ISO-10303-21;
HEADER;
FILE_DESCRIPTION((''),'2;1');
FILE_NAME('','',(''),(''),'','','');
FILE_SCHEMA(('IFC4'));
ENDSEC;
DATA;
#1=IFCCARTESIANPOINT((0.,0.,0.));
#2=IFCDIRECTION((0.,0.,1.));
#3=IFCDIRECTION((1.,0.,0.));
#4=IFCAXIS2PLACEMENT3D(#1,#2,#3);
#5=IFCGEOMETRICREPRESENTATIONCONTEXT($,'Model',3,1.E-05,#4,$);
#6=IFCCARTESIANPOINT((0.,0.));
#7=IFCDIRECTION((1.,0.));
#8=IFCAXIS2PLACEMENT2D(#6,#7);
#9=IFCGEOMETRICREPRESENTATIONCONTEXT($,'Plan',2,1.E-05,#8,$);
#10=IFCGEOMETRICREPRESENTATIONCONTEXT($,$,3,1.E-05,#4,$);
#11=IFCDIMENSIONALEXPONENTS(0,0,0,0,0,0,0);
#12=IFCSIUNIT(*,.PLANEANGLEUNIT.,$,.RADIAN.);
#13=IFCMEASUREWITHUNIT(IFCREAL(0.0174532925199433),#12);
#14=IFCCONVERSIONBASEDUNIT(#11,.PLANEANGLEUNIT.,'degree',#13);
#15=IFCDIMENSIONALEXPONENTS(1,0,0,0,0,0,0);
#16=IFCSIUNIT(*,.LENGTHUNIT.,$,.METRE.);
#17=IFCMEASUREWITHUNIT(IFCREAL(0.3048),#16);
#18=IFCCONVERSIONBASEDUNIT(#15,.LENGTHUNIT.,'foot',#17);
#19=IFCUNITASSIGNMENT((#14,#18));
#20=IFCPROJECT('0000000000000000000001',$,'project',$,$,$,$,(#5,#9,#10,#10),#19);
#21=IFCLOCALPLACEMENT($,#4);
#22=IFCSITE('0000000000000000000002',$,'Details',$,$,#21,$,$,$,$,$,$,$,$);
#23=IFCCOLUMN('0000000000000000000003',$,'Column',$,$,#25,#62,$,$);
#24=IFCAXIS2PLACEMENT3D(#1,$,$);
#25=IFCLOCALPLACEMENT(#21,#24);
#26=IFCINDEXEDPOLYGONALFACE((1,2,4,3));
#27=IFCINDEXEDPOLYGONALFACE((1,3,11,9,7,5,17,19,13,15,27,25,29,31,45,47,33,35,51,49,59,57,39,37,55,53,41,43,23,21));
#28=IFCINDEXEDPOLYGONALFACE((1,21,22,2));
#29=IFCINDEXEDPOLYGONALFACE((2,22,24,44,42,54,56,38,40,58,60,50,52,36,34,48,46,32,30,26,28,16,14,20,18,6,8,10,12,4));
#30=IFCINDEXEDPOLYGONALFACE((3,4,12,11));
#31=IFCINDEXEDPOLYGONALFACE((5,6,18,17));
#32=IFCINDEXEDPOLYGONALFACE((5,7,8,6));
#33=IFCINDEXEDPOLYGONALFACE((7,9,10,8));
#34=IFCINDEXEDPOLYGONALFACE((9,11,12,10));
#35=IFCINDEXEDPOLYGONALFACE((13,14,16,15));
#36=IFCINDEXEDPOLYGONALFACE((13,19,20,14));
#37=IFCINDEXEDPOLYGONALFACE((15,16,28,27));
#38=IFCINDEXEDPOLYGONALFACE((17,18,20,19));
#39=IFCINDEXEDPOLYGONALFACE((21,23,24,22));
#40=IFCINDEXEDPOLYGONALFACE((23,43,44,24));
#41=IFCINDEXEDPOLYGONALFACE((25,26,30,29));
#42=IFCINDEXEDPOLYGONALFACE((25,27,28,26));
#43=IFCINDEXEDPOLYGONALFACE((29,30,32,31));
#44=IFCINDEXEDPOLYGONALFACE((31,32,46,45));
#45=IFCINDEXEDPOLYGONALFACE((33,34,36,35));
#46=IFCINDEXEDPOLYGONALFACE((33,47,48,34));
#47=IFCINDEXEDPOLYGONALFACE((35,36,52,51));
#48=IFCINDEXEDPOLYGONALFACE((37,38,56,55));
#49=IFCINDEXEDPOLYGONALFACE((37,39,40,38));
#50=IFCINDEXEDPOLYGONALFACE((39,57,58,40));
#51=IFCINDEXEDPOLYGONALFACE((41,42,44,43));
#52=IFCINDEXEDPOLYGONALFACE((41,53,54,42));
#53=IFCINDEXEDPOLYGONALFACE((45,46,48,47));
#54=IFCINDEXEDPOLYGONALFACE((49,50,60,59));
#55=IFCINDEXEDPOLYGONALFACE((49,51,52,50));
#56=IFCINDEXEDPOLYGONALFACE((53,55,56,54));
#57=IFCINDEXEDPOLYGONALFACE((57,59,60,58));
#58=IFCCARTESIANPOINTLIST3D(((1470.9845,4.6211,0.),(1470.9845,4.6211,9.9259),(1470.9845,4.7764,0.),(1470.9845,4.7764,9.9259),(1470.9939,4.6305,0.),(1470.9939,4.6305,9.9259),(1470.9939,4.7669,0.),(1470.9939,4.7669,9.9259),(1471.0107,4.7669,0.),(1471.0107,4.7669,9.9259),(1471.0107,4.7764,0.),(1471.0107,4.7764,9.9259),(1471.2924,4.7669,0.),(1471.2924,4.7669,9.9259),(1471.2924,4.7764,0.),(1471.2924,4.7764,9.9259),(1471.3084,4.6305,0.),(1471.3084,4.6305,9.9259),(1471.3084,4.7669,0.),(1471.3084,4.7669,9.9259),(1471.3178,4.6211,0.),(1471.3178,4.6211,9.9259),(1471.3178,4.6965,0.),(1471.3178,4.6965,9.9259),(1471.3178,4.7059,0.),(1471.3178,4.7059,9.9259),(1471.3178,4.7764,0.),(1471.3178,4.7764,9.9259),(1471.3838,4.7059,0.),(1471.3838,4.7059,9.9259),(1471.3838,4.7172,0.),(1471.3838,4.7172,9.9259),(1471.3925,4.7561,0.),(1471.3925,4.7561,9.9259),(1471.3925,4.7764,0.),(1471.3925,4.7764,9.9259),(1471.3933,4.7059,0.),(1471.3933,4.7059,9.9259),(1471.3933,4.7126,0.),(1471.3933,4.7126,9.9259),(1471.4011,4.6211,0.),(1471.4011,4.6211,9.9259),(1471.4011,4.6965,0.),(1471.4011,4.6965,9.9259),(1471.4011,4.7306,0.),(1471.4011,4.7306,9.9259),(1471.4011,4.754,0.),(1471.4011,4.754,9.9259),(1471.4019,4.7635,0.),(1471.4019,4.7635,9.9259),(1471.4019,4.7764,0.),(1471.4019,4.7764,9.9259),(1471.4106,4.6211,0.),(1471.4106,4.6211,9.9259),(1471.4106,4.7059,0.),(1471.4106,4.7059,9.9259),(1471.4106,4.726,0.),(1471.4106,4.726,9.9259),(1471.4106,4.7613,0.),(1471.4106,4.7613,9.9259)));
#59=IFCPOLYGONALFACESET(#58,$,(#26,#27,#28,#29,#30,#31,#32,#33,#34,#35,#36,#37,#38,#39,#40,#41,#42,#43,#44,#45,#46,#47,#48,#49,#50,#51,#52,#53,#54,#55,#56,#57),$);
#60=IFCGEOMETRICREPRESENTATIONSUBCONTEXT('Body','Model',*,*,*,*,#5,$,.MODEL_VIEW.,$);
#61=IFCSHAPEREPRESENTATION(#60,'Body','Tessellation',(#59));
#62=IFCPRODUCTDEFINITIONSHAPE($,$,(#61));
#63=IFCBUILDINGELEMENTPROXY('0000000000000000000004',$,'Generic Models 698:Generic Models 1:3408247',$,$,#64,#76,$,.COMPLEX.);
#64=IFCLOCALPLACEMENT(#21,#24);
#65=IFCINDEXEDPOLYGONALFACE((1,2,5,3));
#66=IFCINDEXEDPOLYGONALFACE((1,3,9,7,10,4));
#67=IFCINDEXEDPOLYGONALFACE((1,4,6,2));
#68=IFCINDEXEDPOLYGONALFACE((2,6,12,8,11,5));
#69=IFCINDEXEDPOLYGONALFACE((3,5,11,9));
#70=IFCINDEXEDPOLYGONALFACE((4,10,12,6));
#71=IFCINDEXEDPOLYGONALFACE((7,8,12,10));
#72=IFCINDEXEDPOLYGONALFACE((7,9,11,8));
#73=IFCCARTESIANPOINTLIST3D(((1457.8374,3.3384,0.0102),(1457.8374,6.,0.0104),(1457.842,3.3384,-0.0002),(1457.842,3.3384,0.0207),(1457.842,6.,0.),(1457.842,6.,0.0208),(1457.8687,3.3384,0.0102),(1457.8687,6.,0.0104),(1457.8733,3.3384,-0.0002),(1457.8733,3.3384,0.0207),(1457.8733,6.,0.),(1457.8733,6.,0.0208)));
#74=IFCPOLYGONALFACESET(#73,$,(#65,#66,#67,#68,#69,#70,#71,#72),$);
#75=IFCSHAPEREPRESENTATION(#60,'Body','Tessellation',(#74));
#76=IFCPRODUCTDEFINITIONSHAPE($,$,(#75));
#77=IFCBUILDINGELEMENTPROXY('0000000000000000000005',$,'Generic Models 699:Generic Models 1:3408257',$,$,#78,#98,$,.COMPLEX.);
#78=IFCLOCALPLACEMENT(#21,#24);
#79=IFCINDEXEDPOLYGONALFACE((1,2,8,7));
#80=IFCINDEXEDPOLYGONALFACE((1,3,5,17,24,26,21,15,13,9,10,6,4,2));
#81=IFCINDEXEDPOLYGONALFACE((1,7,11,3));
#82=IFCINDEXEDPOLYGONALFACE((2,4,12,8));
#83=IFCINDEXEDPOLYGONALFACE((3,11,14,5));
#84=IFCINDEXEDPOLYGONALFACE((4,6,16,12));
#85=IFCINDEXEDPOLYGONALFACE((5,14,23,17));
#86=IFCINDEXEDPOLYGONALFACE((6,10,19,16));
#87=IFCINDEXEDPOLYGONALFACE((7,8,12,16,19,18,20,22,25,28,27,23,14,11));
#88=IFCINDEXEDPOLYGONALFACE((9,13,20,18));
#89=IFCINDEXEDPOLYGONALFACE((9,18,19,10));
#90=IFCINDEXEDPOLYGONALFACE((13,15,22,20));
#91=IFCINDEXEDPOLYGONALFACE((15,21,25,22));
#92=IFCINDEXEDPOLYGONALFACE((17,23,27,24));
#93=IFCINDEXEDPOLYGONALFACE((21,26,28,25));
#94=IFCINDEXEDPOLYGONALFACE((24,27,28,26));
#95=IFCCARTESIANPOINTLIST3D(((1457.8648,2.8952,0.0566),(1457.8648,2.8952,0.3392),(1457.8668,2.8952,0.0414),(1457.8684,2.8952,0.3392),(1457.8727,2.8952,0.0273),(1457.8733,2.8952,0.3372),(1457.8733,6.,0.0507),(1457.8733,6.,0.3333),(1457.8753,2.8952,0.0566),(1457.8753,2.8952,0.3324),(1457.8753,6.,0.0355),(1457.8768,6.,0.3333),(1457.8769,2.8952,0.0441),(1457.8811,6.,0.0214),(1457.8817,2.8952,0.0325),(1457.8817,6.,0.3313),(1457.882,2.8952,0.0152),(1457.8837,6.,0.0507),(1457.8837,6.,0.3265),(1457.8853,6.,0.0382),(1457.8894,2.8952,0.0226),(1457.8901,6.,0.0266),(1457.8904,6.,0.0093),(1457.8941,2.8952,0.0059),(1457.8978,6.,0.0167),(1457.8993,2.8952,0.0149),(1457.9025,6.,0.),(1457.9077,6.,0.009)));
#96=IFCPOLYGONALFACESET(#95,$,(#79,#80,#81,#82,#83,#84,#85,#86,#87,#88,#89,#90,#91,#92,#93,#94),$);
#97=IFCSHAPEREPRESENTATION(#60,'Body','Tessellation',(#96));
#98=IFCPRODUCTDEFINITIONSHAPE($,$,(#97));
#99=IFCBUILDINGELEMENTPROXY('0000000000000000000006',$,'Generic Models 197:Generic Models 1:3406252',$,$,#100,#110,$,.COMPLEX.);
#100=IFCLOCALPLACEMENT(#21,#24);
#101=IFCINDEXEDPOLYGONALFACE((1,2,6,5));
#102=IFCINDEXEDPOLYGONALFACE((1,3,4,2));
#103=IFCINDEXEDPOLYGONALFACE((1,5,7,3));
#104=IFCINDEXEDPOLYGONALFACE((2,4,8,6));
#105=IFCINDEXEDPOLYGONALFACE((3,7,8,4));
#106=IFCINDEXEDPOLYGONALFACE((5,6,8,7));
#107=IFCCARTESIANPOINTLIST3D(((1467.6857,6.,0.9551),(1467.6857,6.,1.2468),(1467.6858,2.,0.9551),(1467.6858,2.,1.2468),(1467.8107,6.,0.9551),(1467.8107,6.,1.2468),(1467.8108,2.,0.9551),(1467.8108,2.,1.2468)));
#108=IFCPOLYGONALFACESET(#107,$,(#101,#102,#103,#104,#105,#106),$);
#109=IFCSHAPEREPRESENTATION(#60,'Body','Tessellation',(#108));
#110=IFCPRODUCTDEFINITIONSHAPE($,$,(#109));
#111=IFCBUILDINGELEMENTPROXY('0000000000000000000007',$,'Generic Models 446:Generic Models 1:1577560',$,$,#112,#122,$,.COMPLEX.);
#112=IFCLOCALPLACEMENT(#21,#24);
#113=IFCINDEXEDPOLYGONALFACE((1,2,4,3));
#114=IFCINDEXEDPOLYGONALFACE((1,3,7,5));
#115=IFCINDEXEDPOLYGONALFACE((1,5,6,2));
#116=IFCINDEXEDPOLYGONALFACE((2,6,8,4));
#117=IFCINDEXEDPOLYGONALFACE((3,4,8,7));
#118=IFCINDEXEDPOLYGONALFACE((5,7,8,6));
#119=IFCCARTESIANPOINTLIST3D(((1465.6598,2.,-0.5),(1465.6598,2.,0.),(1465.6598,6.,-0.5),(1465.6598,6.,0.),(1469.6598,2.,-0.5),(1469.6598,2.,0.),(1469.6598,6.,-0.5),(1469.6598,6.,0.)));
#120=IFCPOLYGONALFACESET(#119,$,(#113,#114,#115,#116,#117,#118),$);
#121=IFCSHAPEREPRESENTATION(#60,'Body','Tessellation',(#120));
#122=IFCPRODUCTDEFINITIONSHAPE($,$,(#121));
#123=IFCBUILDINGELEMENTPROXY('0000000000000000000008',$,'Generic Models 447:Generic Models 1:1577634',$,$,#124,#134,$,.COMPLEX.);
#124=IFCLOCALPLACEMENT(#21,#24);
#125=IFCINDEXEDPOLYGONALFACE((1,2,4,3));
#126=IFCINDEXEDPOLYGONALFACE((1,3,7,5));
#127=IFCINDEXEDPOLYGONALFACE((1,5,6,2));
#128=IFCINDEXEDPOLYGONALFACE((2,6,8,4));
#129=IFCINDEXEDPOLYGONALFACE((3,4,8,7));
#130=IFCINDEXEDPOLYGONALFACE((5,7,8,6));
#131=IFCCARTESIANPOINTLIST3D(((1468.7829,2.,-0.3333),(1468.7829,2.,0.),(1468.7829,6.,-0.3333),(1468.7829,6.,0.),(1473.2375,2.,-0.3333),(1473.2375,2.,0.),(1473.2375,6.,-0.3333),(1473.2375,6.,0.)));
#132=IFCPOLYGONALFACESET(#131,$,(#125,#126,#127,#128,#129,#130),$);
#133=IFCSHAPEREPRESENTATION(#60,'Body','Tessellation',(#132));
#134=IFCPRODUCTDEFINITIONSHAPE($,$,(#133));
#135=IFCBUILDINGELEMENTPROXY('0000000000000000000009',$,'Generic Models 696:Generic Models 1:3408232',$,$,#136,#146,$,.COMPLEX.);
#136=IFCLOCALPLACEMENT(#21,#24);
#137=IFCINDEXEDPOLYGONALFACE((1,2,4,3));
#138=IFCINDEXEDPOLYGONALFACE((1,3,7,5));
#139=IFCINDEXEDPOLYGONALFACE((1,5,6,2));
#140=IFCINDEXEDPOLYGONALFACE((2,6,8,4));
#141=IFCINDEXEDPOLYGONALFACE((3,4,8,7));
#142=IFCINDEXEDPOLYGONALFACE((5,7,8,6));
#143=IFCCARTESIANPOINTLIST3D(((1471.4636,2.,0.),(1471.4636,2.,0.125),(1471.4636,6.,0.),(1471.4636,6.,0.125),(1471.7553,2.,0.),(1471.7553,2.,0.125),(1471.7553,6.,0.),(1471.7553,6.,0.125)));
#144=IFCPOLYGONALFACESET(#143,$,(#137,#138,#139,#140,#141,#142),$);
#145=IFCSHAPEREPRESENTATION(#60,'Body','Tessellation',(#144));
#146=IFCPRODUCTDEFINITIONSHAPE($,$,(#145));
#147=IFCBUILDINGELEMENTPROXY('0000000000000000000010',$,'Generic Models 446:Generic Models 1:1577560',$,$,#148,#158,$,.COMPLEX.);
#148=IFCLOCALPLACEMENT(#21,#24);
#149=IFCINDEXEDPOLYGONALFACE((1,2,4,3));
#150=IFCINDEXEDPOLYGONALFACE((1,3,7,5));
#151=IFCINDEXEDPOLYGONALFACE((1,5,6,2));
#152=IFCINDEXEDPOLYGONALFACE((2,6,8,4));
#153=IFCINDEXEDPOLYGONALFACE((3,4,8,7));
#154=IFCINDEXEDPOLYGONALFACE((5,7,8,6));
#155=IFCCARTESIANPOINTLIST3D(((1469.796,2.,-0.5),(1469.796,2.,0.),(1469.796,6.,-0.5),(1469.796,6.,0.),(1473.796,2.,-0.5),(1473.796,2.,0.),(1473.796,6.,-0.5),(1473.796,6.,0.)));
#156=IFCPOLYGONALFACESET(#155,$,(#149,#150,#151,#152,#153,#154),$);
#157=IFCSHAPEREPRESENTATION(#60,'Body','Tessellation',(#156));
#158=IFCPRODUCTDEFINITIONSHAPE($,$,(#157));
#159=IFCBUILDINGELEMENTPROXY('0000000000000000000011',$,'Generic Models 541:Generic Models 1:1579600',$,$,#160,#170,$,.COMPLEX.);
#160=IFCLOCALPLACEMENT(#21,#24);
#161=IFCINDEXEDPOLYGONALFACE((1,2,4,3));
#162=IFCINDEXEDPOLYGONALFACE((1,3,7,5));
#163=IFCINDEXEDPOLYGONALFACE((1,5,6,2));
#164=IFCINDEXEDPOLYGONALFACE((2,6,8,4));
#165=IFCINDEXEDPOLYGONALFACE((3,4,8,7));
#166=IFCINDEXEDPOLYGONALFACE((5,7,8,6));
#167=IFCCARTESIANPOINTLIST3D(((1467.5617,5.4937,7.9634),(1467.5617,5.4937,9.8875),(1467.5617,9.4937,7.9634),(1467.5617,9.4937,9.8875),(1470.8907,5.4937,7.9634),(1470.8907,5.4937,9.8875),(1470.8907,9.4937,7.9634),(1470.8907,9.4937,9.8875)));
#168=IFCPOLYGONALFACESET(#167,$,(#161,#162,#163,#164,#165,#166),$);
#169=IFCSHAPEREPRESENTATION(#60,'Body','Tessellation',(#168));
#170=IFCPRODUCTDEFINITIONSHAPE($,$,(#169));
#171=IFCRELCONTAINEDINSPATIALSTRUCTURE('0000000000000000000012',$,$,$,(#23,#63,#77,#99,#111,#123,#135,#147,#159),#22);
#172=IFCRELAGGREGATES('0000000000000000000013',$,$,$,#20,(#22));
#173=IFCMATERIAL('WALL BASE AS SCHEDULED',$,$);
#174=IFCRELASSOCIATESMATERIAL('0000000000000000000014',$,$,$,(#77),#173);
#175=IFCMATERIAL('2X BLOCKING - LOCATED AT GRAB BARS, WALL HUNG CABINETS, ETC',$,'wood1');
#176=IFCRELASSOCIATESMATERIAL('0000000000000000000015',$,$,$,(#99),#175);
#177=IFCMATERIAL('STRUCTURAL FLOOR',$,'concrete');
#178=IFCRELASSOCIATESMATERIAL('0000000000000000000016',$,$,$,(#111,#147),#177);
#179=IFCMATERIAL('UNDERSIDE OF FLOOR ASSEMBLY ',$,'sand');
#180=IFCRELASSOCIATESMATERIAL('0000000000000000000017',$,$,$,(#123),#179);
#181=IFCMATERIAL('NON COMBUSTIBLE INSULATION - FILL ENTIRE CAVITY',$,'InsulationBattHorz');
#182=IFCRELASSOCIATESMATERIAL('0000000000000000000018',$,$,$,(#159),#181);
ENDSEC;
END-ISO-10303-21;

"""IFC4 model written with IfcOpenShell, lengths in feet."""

from ifc_helpers import new_model, entity, si_unit, converted_unit, frame, origin_with_axes, origin_2d_with_axis, place, context, subcontext, project, spatial, polyline, line, indexed_curve, outline, extrude, material, element, save


model = new_model("IFC4")

# Units and contexts
model_context = context("Model", 3, precision=1e-05, world=origin_with_axes())
plan_context = context("Plan", 2, precision=1e-05, world=origin_2d_with_axis())
context_of_model = context(None, 3, precision=1e-05, world=origin_with_axes())
body_context = subcontext(model_context, "Body", "Model", "MODEL_VIEW")
ifc_project = project(units=[converted_unit("PLANEANGLEUNIT", "degree", entity("IfcReal", 0.0174532925199433), si_unit("PLANEANGLEUNIT", "RADIAN"), dimensions=[0, 0, 0, 0, 0, 0, 0]), converted_unit("LENGTHUNIT", "foot", entity("IfcReal", 0.3048), si_unit("LENGTHUNIT", "METRE"), dimensions=[1, 0, 0, 0, 0, 0, 0])], contexts=[model_context, plan_context, context_of_model, context_of_model])

# Site
site_placement = place(None, origin_with_axes())
site = spatial("IfcSite", under=ifc_project, at=site_placement, Name="Details")

# Column
for number, where, z_axis, x_axis, name in (
    (1, (1470.9845, 4.6211, 0.0), (0.0, 0.0, 1.0), (1.0, 0.0, 0.0), "Column"),
):
    element("IfcColumn", number, at=place(site_placement, frame(where, z_axis=z_axis, x_axis=x_axis)), inside=site, Name=name, context=body_context, shape_type="SweptSolid", body=[
        extrude(outline(polyline([(-0.041, -0.1159), (-0.0057, -0.1159), (0.0077, -0.0986), (0.0144, -0.0986), (0.0144, -0.1159), (0.0992, -0.1159), (0.0992, -0.1064), (0.0238, -0.1064), (0.0238, -0.0231), (0.0992, -0.0231), (0.0992, 0.3102), (-0.0561, 0.3102), (-0.0561, 0.284), (-0.0466, 0.284), (-0.0466, 0.3008), (0.0898, 0.3008), (0.0898, -0.0137), (-0.0466, -0.0137), (-0.0466, 0.0023), (-0.0561, 0.0023), (-0.0561, -0.0231), (0.0144, -0.0231), (0.0144, -0.0891), (0.0031, -0.0891), (-0.0103, -0.1064), (-0.0337, -0.1064), (-0.0358, -0.0978), (-0.0561, -0.0978), (-0.0561, -0.1072), (-0.0432, -0.1072), (-0.041, -0.1159)])), frame((0.3102, 0.0992, 0.0), z_axis=(0.0, 0.0, -1.0), x_axis=(0.0, -1.0, 0.0)), (0.0, 0.0, -1.0), 9.9259),
    ])

# Building element proxies
proxy_1_placement = place(site_placement, frame((1457.8375, 6.0, 0.0), z_axis=(0.0, -1.0, 0.0), x_axis=(0.0, 0.0, 1.0)))
element("IfcBuildingElementProxy", 2, at=proxy_1_placement, inside=site, Name="Generic Models 698:Generic Models 1:3408247", PredefinedType="COMPLEX", context=body_context, shape_type="SweptSolid", body=[
    extrude(outline(polyline([(0.0201, 0.0), (0.0107, 0.0065), (0.0093, 0.0178), (-0.0175, 0.0016), (-0.016, -0.0097), (-0.0066, -0.0162), (0.0201, 0.0)])), frame((0.0104, -0.0186, 0.0), z_axis=(0.0, 0.0, -1.0), x_axis=(0.51911, -0.854707, 0.0)), (-0.000034, 0.000057, -1.0), 2.6616),
])
ifc_material_1 = material(Name="WALL BASE AS SCHEDULED")
proxy_2_placement = place(site_placement, frame((1457.8733, 6.0, 0.0), z_axis=(0.0, -1.0, 0.0), x_axis=(0.0, 0.0, 1.0)))
element("IfcBuildingElementProxy", 3, at=proxy_2_placement, inside=site, material=ifc_material_1, Name="Generic Models 699:Generic Models 1:3408257", PredefinedType="COMPLEX", context=body_context, shape_type="SweptSolid", body=[
    extrude(outline(polyline([(0.2206, 0.0), (0.2204, 0.0036), (0.2182, 0.0083), (0.2132, 0.01), (-0.0621, -0.0058), (-0.0747, -0.0049), (-0.0865, -0.0007), (-0.0969, 0.0063), (-0.1051, 0.0158), (-0.1138, 0.0101), (-0.1038, -0.0014), (-0.0912, -0.01), (-0.0768, -0.0151), (-0.0615, -0.0162), (0.2206, 0.0)])), frame((0.113, -0.0126, 0.0), z_axis=(0.0, 0.0, -1.0), x_axis=(0.998358, 0.057286, 0.0)), (0.002054, -0.002598, -0.999995), 3.1048),
])
ifc_material_2 = material(Name="2X BLOCKING - LOCATED AT GRAB BARS, WALL HUNG CABINETS, ETC", Category="wood1")
for number, where, z_axis, x_axis, name in (
    (4, (1467.6857, 6.0, 0.9551), (0.0, -1.0, 0.0), (0.0, 0.0, 1.0), "Generic Models 197:Generic Models 1:3406252"),
):
    element("IfcBuildingElementProxy", number, at=place(site_placement, frame(where, z_axis=z_axis, x_axis=x_axis)), inside=site, material=ifc_material_2, Name=name, PredefinedType="COMPLEX", context=body_context, shape_type="SweptSolid", body=[
        extrude(outline(polyline([(-0.0625, -0.1458), (0.0625, -0.1458), (0.0625, 0.1458), (-0.0625, 0.1458), (-0.0625, -0.1458)])), frame((0.1458, -0.0625, 0.0), z_axis=(0.0, 0.0, -1.0), x_axis=(0.0, 1.0, 0.0)), (0.0, 0.0, -1.0), 4.0),
    ])
ifc_material_3 = material(Name="STRUCTURAL FLOOR", Category="concrete")
proxy_3_placement = place(site_placement, frame((1465.6598, 6.0, -0.5), z_axis=(0.0, -1.0, 0.0), x_axis=(0.0, 0.0, 1.0)))
element("IfcBuildingElementProxy", 5, at=proxy_3_placement, inside=site, material=ifc_material_3, Name="Generic Models 446:Generic Models 1:1577560", PredefinedType="COMPLEX", context=body_context, shape_type="SweptSolid", body=[
    extrude(outline(polyline([(-2.0, -0.25), (2.0, -0.25), (2.0, 0.25), (-2.0, 0.25), (-2.0, -0.25)])), frame((0.25, -2.0, 0.0), z_axis=(0.0, 0.0, -1.0), x_axis=(0.0, 1.0, 0.0)), (0.0, 0.0, -1.0), 4.0),
])
ifc_material_4 = material(Name="UNDERSIDE OF FLOOR ASSEMBLY ", Category="sand")
proxy_4_placement = place(site_placement, frame((1468.7829, 6.0, -0.3333), z_axis=(0.0, -1.0, 0.0), x_axis=(0.0, 0.0, 1.0)))
element("IfcBuildingElementProxy", 6, at=proxy_4_placement, inside=site, material=ifc_material_4, Name="Generic Models 447:Generic Models 1:1577634", PredefinedType="COMPLEX", context=body_context, shape_type="SweptSolid", body=[
    extrude(outline(indexed_curve([(-2.4546, -0.1667), (2.0, -0.1667), (2.0, 0.1667), (-2.4546, 0.1667)], segments=[line(3, 2), line(2, 1), line(1, 4), line(4, 3)], self_intersect=False)), frame((0.1667, -2.0, 0.0), z_axis=(0.0, 0.0, -1.0), x_axis=(0.0, 1.0, 0.0)), (0.0, 0.0, -1.0), 4.0),
])
proxy_5_placement = place(site_placement, frame((1471.4636, 6.0, 0.0), z_axis=(0.0, -1.0, 0.0), x_axis=(0.0, 0.0, 1.0)))
element("IfcBuildingElementProxy", 7, at=proxy_5_placement, inside=site, Name="Generic Models 696:Generic Models 1:3408232", PredefinedType="COMPLEX", context=body_context, shape_type="SweptSolid", body=[
    extrude(outline(polyline([(-0.0625, -0.1458), (0.0625, -0.1458), (0.0625, 0.1458), (-0.0625, 0.1458), (-0.0625, -0.1458)])), frame((0.0625, -0.1458, 0.0), z_axis=(0.0, 0.0, -1.0), x_axis=(1.0, 0.0, 0.0)), (0.0, 0.0, -1.0), 4.0),
])
proxy_6_placement = place(site_placement, frame((1469.796, 6.0, -0.5), z_axis=(0.0, -1.0, 0.0), x_axis=(0.0, 0.0, 1.0)))
element("IfcBuildingElementProxy", 8, at=proxy_6_placement, inside=site, material=ifc_material_3, Name="Generic Models 446:Generic Models 1:1577560", PredefinedType="COMPLEX", context=body_context, shape_type="SweptSolid", body=[
    extrude(outline(polyline([(-2.0, -0.25), (2.0, -0.25), (2.0, 0.25), (-2.0, 0.25), (-2.0, -0.25)])), frame((0.25, -2.0, 0.0), z_axis=(0.0, 0.0, -1.0), x_axis=(0.0, 1.0, 0.0)), (0.0, 0.0, -1.0), 4.0),
])
ifc_material_5 = material(Name="NON COMBUSTIBLE INSULATION - FILL ENTIRE CAVITY", Category="InsulationBattHorz")
proxy_7_placement = place(site_placement, frame((1470.2593, 9.4937, -0.055), z_axis=(0.0, -1.0, 0.0), x_axis=(0.0, 0.0, 1.0)))
element("IfcBuildingElementProxy", 9, at=proxy_7_placement, inside=site, material=ifc_material_5, Name="Generic Models 541:Generic Models 1:1579600", PredefinedType="COMPLEX", context=body_context, shape_type="SweptSolid", body=[
    extrude(outline(polyline([(-0.9621, -1.6645), (0.9621, -1.6645), (0.9621, 1.6645), (-0.9621, 1.6645), (-0.9621, -1.6645)])), frame((8.9804, 1.0331, 0.0), z_axis=(0.0, 0.0, -1.0), x_axis=(-1.0, -0.000001, 0.0)), (0.0, 0.0, -1.0), 4.0),
])

save(model, "model.ifc")
